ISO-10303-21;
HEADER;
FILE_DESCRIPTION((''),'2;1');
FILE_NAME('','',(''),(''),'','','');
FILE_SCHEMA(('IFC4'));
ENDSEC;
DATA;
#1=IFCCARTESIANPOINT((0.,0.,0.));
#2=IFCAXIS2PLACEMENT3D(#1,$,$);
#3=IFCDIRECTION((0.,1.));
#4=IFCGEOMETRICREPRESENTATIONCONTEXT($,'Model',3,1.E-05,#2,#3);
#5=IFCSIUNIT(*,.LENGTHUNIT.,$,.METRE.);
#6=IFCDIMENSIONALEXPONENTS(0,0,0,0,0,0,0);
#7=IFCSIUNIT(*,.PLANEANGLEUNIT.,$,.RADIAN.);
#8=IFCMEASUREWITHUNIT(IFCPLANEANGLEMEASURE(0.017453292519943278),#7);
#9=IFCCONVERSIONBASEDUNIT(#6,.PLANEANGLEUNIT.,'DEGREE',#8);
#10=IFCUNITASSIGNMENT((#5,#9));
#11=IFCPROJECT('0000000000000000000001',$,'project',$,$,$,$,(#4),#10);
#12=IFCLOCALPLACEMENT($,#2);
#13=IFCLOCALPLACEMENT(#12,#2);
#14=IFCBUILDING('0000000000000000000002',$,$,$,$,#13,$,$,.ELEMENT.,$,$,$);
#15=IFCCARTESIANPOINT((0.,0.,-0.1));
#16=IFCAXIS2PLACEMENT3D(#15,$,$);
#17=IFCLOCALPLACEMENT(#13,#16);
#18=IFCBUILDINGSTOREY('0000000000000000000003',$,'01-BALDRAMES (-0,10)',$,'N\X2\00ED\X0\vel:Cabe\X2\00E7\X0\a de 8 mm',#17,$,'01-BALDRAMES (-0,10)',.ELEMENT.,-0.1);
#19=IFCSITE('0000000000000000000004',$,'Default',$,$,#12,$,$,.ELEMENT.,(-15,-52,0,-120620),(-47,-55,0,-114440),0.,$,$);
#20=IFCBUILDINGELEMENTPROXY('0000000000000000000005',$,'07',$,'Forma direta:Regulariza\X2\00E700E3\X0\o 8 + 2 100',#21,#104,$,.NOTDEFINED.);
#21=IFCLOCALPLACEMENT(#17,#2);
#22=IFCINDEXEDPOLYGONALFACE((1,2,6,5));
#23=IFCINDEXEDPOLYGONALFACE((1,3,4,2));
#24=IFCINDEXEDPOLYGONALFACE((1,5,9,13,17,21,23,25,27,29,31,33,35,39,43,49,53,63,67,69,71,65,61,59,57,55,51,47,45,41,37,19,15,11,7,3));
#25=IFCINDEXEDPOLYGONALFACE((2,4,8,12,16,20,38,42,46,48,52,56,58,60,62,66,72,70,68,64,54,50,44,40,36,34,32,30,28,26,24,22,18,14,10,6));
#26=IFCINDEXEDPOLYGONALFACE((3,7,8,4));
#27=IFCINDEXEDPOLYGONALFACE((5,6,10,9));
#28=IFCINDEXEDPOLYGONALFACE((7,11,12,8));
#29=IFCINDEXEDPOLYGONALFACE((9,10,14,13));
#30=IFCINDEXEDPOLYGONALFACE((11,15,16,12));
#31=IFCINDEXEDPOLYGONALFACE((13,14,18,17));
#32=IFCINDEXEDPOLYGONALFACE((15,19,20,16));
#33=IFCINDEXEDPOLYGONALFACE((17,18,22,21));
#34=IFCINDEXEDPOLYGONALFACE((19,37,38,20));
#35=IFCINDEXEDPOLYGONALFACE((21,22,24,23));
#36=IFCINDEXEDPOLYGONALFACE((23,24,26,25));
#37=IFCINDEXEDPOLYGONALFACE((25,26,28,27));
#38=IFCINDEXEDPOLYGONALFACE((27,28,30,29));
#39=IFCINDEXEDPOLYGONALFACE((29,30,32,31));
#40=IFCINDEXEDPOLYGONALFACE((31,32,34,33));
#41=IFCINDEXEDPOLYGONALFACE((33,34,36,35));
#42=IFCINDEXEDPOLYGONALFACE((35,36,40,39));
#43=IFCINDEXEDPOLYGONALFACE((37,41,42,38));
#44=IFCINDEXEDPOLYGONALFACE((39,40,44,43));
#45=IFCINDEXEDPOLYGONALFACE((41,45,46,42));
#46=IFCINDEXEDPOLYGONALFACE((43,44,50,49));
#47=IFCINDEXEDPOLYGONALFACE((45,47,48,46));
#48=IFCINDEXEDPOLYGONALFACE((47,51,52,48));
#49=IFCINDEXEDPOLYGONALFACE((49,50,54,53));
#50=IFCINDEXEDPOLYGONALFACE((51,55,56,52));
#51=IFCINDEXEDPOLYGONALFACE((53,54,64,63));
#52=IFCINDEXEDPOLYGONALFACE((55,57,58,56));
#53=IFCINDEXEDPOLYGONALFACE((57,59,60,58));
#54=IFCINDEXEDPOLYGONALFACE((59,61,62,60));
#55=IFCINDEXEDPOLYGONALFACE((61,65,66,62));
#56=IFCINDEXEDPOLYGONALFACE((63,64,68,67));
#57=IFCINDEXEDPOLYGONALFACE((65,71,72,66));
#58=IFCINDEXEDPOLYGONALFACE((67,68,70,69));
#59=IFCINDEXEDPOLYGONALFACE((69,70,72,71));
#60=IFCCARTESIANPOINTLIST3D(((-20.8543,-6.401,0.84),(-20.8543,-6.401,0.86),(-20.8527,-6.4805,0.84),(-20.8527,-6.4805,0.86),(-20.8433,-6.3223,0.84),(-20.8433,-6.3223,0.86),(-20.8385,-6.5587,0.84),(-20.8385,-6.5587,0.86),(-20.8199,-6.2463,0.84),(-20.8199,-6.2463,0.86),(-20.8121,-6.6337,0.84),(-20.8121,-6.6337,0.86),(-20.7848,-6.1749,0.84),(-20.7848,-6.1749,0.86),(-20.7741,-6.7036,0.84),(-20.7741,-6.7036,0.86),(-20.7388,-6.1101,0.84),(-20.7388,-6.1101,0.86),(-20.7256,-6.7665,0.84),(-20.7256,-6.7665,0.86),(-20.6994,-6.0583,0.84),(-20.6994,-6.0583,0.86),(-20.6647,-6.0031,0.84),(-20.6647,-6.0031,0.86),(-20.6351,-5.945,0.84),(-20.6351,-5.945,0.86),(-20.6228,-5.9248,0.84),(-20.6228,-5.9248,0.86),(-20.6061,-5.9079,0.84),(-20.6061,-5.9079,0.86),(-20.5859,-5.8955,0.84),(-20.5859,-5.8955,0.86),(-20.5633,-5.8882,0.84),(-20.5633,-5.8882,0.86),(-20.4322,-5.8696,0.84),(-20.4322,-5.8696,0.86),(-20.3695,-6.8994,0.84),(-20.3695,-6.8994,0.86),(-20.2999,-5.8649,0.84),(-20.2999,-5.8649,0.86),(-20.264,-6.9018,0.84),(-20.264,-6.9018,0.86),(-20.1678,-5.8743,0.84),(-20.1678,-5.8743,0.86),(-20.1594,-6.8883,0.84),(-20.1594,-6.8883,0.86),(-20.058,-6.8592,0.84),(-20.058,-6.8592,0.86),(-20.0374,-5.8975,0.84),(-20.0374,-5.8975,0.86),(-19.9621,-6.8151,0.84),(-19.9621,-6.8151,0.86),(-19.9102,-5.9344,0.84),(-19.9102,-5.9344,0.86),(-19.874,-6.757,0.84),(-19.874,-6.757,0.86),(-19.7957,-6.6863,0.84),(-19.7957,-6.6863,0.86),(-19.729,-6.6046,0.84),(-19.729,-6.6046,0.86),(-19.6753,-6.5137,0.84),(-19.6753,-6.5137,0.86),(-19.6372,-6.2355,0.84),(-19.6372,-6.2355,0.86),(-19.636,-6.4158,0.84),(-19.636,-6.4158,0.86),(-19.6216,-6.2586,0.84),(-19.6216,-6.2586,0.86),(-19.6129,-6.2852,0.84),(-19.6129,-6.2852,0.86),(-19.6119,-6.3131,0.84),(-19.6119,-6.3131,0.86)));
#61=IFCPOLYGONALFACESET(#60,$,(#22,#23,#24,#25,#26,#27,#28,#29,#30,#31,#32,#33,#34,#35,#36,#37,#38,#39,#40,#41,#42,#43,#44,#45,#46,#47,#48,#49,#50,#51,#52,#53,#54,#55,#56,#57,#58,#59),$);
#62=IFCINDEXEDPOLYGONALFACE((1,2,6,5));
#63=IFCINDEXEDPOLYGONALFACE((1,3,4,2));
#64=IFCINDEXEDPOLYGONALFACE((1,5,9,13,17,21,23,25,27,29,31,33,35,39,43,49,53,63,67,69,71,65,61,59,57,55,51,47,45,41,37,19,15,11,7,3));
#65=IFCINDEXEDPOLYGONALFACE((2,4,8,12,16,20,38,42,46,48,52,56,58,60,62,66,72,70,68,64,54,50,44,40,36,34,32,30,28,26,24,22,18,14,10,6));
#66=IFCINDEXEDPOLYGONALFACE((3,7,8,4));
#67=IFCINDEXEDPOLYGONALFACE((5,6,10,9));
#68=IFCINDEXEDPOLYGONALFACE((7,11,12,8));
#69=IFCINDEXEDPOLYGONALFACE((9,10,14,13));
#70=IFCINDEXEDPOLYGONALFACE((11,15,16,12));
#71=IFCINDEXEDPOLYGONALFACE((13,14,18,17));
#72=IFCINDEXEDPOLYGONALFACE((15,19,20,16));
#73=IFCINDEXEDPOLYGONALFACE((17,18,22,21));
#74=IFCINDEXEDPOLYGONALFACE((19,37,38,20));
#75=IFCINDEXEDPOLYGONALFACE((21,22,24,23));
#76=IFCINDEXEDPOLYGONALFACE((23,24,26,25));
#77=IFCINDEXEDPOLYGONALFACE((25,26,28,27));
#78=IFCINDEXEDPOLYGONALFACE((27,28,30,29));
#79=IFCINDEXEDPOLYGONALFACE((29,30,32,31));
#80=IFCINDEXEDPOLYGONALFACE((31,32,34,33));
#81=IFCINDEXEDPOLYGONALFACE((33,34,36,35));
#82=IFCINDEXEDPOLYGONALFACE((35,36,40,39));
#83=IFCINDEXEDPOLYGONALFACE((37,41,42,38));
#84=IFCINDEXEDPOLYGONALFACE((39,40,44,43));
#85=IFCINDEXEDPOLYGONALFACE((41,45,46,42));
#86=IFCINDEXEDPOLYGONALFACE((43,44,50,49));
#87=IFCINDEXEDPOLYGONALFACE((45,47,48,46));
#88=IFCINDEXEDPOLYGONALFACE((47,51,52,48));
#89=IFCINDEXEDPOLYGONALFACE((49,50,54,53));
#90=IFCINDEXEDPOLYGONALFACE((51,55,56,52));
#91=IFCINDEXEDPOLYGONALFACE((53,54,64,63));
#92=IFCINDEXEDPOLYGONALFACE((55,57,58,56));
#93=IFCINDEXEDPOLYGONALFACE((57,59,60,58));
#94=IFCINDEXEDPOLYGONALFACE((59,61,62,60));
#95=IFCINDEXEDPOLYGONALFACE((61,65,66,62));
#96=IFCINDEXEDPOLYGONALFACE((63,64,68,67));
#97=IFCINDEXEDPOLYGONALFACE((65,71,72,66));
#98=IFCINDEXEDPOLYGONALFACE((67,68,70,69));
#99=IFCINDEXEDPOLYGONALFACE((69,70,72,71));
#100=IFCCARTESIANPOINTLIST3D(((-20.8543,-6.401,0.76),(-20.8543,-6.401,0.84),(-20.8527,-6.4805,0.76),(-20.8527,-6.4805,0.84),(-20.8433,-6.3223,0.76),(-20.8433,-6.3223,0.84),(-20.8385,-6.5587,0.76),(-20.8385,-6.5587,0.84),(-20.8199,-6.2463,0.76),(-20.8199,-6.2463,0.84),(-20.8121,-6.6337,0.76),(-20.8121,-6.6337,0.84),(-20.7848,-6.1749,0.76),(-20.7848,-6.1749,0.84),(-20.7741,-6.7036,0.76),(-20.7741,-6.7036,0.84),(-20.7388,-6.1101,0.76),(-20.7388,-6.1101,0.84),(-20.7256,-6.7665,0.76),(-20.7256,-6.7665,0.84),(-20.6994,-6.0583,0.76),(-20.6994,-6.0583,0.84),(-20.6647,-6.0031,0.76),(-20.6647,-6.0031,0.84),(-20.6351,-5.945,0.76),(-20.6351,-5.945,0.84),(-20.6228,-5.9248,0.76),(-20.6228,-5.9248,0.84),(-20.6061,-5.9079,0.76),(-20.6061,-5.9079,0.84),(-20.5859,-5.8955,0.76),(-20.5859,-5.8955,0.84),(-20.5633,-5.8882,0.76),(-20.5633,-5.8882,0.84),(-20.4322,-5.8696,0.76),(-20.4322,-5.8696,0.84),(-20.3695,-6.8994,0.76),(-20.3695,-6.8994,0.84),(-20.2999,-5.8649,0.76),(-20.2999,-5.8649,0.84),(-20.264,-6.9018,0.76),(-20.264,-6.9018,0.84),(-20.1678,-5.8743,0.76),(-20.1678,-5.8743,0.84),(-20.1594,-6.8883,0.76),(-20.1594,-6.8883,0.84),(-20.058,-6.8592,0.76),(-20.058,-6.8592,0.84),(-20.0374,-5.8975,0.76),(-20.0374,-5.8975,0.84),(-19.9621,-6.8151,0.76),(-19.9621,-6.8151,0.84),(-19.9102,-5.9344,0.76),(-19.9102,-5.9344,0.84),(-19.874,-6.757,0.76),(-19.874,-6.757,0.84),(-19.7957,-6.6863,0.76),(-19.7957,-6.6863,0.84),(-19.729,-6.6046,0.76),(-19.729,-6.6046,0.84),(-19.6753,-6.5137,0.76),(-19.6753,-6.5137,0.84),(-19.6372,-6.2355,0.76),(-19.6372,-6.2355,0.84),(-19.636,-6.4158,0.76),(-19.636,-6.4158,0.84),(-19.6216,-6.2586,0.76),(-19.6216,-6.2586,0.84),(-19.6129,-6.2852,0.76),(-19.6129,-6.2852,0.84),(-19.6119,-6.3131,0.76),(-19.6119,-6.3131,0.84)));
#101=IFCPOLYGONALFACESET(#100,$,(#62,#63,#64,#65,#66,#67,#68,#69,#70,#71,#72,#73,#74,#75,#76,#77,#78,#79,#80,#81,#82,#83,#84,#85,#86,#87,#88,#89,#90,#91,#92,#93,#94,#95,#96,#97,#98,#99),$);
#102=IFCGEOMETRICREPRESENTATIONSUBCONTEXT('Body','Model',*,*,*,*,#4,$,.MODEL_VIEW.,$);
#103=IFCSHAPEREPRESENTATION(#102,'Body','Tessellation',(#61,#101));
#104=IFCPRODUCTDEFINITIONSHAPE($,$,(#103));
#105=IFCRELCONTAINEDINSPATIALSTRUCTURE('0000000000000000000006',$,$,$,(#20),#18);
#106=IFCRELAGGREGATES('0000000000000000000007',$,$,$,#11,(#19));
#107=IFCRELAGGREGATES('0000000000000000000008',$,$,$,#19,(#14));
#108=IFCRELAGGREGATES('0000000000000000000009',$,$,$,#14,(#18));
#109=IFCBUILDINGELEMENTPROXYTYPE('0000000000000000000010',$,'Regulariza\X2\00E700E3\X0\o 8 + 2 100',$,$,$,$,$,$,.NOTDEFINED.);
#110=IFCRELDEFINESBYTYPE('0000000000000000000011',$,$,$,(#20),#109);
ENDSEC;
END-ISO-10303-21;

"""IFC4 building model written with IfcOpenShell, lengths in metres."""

from ifc_helpers import new_model, entity, si_unit, converted_unit, direction, frame, origin, place, context, subcontext, project, spatial, line, arc, indexed_curve, outline, extrude, type_object, element, save


model = new_model("IFC4")

# Units and contexts
model_context = context("Model", 3, precision=1e-05, world=origin(), true_north=direction((0.0, 1.0)))
body_context = subcontext(model_context, "Body", "Model", "MODEL_VIEW")
ifc_project = project(units=[si_unit("LENGTHUNIT", "METRE"), converted_unit("PLANEANGLEUNIT", "DEGREE", entity("IfcPlaneAngleMeasure", 0.017453292519943278), si_unit("PLANEANGLEUNIT", "RADIAN"), dimensions=[0, 0, 0, 0, 0, 0, 0])], contexts=[model_context])

# Site, building, storey
site_placement = place(None, origin())
site = spatial("IfcSite", under=ifc_project, at=site_placement, Name="Default", CompositionType="ELEMENT", RefLatitude=(-15, -52, 0, -120620), RefLongitude=(-47, -55, 0, -114440), RefElevation=0.0)
building_placement = place(site_placement, origin())
building = spatial("IfcBuilding", under=site, at=building_placement, CompositionType="ELEMENT")
storey_placement = place(building_placement, frame((0.0, 0.0, -0.1)))
storey = spatial("IfcBuildingStorey", under=building, at=storey_placement, Name="01-BALDRAMES (-0,10)", ObjectType="Nível:Cabeça de 8 mm", LongName="01-BALDRAMES (-0,10)", CompositionType="ELEMENT", Elevation=-0.1)

# Building element proxy
building_element_proxy_type_1 = type_object("IfcBuildingElementProxyType", Name="Regularização 8 + 2 100", PredefinedType="NOTDEFINED")
proxy_1_placement = place(storey_placement, origin())
element("IfcBuildingElementProxy", 1, at=proxy_1_placement, inside=storey, type_object=building_element_proxy_type_1, Name="07", ObjectType="Forma direta:Regularização 8 + 2 100", PredefinedType="NOTDEFINED", context=body_context, shape_type="SweptSolid", body=[
    extrude(outline(indexed_curve([(0.6639, 0.0179), (0.6551, 0.0588), (0.6305, 0.0925), (0.3276, 0.3633), (-0.0011, 0.3957), (-0.3268, 0.341), (-0.3673, 0.3169), (-0.3923, 0.277), (-0.4293, 0.1866), (-0.4782, 0.102), (-0.5592, -0.239), (-0.3964, -0.5495), (-0.0283, -0.6444), (0.4495, -0.4509)], segments=[arc(1, 2, 3), line(3, 4), arc(4, 5, 6), arc(6, 7, 8), arc(8, 9, 10), arc(10, 11, 12), line(12, 13), arc(13, 14, 1)], self_intersect=False)), frame((-20.274, -6.2615, 0.84), z_axis=(0.0, 0.0, 1.0), x_axis=(0.99452, -0.104545, 0.0)), (0.0, 0.0, 1.0), 0.02),
    extrude(outline(indexed_curve([(0.6639, 0.0179), (0.6551, 0.0588), (0.6305, 0.0925), (0.3276, 0.3633), (-0.0011, 0.3957), (-0.3268, 0.341), (-0.3673, 0.3169), (-0.3923, 0.277), (-0.4293, 0.1866), (-0.4782, 0.102), (-0.5592, -0.239), (-0.3964, -0.5495), (-0.0283, -0.6444), (0.4495, -0.4509)], segments=[arc(1, 2, 3), line(3, 4), arc(4, 5, 6), arc(6, 7, 8), arc(8, 9, 10), arc(10, 11, 12), line(12, 13), arc(13, 14, 1)], self_intersect=False)), frame((-20.274, -6.2615, 0.76), z_axis=(0.0, 0.0, 1.0), x_axis=(0.99452, -0.104545, 0.0)), (0.0, 0.0, 1.0), 0.08),
])

save(model, "model.ifc")
